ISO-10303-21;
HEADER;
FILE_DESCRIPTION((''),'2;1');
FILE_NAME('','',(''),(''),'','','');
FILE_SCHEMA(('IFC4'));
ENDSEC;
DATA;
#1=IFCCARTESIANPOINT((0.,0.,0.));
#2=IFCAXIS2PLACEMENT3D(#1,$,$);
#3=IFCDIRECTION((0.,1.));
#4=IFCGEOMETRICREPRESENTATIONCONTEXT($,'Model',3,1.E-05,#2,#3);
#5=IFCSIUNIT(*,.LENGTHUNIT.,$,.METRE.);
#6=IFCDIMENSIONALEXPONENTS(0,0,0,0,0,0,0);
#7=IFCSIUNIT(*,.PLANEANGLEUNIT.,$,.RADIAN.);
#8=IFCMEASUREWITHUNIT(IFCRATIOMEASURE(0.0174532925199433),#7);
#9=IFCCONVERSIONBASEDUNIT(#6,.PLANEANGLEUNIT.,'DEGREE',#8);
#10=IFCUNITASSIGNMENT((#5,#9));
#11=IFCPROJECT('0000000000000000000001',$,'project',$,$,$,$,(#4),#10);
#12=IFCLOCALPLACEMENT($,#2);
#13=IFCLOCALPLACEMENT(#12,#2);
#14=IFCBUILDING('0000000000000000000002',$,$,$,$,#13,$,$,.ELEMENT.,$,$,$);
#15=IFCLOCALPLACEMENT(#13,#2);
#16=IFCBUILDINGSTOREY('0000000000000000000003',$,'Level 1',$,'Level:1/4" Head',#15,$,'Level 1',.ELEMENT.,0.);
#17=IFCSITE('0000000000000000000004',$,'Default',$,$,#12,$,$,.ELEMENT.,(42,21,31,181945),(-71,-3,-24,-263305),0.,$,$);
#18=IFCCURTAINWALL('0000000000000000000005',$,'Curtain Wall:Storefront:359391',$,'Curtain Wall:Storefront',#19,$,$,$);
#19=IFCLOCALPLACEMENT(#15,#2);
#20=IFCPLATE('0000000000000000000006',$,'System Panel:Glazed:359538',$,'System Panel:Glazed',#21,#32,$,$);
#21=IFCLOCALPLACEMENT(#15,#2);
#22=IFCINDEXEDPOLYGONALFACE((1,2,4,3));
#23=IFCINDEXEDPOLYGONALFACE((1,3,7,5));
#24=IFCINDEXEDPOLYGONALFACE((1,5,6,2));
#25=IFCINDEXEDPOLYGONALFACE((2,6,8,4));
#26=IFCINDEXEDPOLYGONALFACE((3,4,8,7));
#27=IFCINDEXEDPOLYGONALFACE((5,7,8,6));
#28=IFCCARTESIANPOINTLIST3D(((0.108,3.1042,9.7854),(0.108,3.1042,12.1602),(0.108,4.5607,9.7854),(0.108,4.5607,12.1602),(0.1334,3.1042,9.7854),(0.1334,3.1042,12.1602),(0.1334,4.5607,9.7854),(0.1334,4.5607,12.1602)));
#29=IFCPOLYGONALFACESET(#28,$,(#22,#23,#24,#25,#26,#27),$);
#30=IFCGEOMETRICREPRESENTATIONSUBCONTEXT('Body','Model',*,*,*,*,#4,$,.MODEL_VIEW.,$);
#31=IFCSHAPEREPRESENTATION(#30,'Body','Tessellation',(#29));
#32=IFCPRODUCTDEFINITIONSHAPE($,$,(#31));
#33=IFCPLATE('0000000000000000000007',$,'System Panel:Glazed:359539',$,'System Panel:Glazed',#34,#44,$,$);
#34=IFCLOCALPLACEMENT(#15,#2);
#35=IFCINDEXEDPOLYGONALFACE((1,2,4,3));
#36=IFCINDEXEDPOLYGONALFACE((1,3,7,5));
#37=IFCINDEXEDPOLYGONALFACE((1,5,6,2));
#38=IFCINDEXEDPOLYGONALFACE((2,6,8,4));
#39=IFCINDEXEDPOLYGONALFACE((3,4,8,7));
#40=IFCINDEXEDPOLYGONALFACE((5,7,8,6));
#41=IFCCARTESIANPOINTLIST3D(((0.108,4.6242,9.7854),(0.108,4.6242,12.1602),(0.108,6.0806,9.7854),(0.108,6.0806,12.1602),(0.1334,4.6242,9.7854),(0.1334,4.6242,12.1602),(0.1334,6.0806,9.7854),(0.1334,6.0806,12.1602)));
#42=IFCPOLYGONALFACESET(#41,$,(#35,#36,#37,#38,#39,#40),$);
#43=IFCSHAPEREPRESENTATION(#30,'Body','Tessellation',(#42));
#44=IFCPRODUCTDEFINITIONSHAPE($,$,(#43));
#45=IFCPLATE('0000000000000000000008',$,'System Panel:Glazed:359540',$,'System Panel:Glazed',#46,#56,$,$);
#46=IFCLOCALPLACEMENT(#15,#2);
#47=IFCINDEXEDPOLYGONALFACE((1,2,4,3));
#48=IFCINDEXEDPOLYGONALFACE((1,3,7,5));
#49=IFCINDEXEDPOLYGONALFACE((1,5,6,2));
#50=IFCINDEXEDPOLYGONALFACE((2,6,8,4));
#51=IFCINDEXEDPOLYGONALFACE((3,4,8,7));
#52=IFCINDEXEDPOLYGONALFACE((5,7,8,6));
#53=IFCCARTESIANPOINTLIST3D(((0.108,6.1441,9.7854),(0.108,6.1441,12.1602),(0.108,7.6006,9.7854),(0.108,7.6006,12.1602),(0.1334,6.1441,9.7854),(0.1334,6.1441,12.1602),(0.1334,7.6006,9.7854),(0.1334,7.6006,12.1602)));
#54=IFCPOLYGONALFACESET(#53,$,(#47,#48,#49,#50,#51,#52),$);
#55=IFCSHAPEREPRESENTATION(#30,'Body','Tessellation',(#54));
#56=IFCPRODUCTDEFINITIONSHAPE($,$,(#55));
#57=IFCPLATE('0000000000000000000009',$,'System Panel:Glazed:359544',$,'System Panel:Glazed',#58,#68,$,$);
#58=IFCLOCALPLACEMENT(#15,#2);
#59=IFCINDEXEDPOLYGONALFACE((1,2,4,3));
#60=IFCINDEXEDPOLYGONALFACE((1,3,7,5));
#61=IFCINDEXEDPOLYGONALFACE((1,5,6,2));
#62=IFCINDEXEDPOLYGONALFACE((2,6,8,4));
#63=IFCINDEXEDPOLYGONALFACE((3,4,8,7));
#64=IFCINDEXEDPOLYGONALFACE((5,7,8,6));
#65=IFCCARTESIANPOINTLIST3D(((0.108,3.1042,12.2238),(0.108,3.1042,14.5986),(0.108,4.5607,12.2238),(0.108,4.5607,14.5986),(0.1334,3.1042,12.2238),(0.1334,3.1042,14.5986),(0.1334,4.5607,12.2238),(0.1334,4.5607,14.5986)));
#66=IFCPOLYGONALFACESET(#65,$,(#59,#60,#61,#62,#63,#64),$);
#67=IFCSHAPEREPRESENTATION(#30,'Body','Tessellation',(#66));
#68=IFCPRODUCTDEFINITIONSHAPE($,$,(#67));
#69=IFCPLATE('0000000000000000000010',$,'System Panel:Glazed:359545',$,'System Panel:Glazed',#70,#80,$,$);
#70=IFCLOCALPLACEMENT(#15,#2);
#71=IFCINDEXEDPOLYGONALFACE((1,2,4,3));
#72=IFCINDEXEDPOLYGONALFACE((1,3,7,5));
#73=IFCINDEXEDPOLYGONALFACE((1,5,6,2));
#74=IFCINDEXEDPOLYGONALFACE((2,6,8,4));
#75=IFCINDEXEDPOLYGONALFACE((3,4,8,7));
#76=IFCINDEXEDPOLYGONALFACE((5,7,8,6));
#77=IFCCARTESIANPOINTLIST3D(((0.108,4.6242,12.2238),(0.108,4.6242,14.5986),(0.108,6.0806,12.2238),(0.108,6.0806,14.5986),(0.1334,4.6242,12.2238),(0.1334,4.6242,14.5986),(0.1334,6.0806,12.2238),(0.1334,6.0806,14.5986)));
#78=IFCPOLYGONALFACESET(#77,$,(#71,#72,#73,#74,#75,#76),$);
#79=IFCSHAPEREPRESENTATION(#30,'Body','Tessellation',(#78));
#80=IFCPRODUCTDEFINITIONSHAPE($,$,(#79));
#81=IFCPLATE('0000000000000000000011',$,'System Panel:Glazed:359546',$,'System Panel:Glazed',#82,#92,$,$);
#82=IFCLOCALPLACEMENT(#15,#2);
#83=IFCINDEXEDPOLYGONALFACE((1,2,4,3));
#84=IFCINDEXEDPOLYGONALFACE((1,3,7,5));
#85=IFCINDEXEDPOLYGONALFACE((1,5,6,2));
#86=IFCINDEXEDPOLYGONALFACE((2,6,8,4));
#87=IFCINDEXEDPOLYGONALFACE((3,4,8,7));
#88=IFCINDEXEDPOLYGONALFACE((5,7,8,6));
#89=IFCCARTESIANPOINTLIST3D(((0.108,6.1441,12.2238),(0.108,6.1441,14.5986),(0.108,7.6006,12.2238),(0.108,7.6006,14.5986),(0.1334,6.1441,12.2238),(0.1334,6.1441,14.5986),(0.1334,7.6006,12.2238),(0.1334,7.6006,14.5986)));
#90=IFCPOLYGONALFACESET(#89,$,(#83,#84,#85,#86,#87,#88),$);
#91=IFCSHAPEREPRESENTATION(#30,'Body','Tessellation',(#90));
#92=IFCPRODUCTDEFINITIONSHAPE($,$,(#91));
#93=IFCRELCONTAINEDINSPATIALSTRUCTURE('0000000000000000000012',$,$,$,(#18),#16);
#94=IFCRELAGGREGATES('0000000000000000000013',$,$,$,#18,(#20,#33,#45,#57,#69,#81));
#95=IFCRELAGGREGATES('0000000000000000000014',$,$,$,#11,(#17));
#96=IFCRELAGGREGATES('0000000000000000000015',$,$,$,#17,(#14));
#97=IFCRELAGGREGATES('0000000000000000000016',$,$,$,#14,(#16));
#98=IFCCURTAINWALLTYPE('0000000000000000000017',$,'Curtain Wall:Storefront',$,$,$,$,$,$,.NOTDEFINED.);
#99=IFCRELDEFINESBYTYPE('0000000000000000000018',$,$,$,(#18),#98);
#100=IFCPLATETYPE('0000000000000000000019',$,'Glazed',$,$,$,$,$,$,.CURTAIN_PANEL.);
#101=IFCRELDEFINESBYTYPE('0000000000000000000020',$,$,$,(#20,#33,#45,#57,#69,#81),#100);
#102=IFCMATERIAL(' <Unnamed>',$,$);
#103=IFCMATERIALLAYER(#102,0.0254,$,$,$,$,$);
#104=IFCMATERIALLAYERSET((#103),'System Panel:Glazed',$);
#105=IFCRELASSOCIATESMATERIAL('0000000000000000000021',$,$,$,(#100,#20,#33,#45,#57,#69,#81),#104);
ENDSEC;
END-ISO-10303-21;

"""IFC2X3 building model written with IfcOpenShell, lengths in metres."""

from ifc_helpers import new_model, entity, si_unit, converted_unit, direction, frame, frame_2d, origin, place, context, subcontext, project, spatial, rectangle, extrude, source, transform, mapped, material, layer, layer_set, layer_usage, type_object, type_shapes, element, aggregate, save


model = new_model("IFC2X3")

# Units and contexts
model_context = context("Model", 3, precision=1e-05, world=origin(), true_north=direction((0.0, 1.0)))
body_context = subcontext(model_context, "Body", "Model", "MODEL_VIEW")
ifc_project = project(units=[si_unit("LENGTHUNIT", "METRE"), converted_unit("PLANEANGLEUNIT", "DEGREE", entity("IfcRatioMeasure", 0.0174532925199433), si_unit("PLANEANGLEUNIT", "RADIAN"), dimensions=[0, 0, 0, 0, 0, 0, 0])], contexts=[model_context])

# Site, building, storey
site_placement = place(None, origin())
site = spatial("IfcSite", under=ifc_project, at=site_placement, Name="Default", CompositionType="ELEMENT", RefLatitude=(42, 21, 31, 181945), RefLongitude=(-71, -3, -24, -263305), RefElevation=0.0)
building_placement = place(site_placement, origin())
building = spatial("IfcBuilding", under=site, at=building_placement, CompositionType="ELEMENT")
storey_placement = place(building_placement, origin())
storey = spatial("IfcBuildingStorey", under=building, at=storey_placement, Name="Level 1", ObjectType="Level:1/4\" Head", LongName="Level 1", CompositionType="ELEMENT", Elevation=0.0)

# Curtain wall, plates
curtain_wall_type = type_object("IfcCurtainWallType", Name="Curtain Wall:Storefront", PredefinedType="NOTDEFINED")
curtain_wall_placement = place(storey_placement, origin())
curtain_wall = element("IfcCurtainWall", 1, at=curtain_wall_placement, inside=storey, type_object=curtain_wall_type, Name="Curtain Wall:Storefront:359391", ObjectType="Curtain Wall:Storefront")
ifc_material_1 = material(Name=" <Unnamed>")
ifc_layer = layer(ifc_material_1, 0.0254)
ifc_layer_set = layer_set([ifc_layer], Name="System Panel:Glazed")
ifc_layer_usage_1 = layer_usage(ifc_layer_set, "AXIS3", "POSITIVE", 0.1042)
plate_type_1 = type_object("IfcPlateType", Name="Glazed", PredefinedType="CURTAIN_PANEL", material=ifc_layer_set)
shared_shape_1 = source(origin(), body_context, "Body", "SweptSolid", [
    extrude(rectangle(XDim=0.0254, YDim=1.4565, at=frame_2d((0.0, 0.0), x_axis=(1.0, 0.0))), frame((0.7282, 0.0127, 0.0), z_axis=(0.0, 0.0, 1.0), x_axis=(0.0, 1.0, 0.0)), (0.0, 0.0, 1.0), 2.3749),
])
type_shapes(plate_type_1, [shared_shape_1])
plate_1_placement = place(curtain_wall_placement, frame((0.1334, 3.1042, 9.7853), z_axis=(0.0, 0.0, 1.0), x_axis=(0.0, 1.0, 0.0)))
plate_1 = element("IfcPlate", 2, at=plate_1_placement, type_object=plate_type_1, material=ifc_layer_usage_1, Name="System Panel:Glazed:359538", ObjectType="System Panel:Glazed", context=body_context, shape_type="MappedRepresentation", body=[
    mapped(shared_shape_1, transform((0.0, 0.0, 0.0), scale=1.0)),
])
ifc_layer_usage_2 = layer_usage(ifc_layer_set, "AXIS3", "POSITIVE", 0.1042)
plate_2_placement = place(curtain_wall_placement, frame((0.1334, 4.6242, 9.7853), z_axis=(0.0, 0.0, 1.0), x_axis=(0.0, 1.0, 0.0)))
plate_2 = element("IfcPlate", 3, at=plate_2_placement, type_object=plate_type_1, material=ifc_layer_usage_2, Name="System Panel:Glazed:359539", ObjectType="System Panel:Glazed", context=body_context, shape_type="MappedRepresentation", body=[
    mapped(shared_shape_1, transform((0.0, 0.0, 0.0), scale=1.0)),
])
ifc_layer_usage_3 = layer_usage(ifc_layer_set, "AXIS3", "POSITIVE", 0.1042)
plate_3_placement = place(curtain_wall_placement, frame((0.1334, 6.1441, 9.7853), z_axis=(0.0, 0.0, 1.0), x_axis=(0.0, 1.0, 0.0)))
plate_3 = element("IfcPlate", 4, at=plate_3_placement, type_object=plate_type_1, material=ifc_layer_usage_3, Name="System Panel:Glazed:359540", ObjectType="System Panel:Glazed", context=body_context, shape_type="MappedRepresentation", body=[
    mapped(shared_shape_1, transform((0.0, 0.0, 0.0), scale=1.0)),
])
ifc_layer_usage_4 = layer_usage(ifc_layer_set, "AXIS3", "POSITIVE", 0.1042)
plate_4_placement = place(curtain_wall_placement, frame((0.1334, 3.1042, 12.2238), z_axis=(0.0, 0.0, 1.0), x_axis=(0.0, 1.0, 0.0)))
plate_4 = element("IfcPlate", 5, at=plate_4_placement, type_object=plate_type_1, material=ifc_layer_usage_4, Name="System Panel:Glazed:359544", ObjectType="System Panel:Glazed", context=body_context, shape_type="MappedRepresentation", body=[
    mapped(shared_shape_1, transform((0.0, 0.0, 0.0), scale=1.0)),
])
ifc_layer_usage_5 = layer_usage(ifc_layer_set, "AXIS3", "POSITIVE", 0.1042)
plate_5_placement = place(curtain_wall_placement, frame((0.1334, 4.6242, 12.2238), z_axis=(0.0, 0.0, 1.0), x_axis=(0.0, 1.0, 0.0)))
plate_5 = element("IfcPlate", 6, at=plate_5_placement, type_object=plate_type_1, material=ifc_layer_usage_5, Name="System Panel:Glazed:359545", ObjectType="System Panel:Glazed", context=body_context, shape_type="MappedRepresentation", body=[
    mapped(shared_shape_1, transform((0.0, 0.0, 0.0), scale=1.0)),
])
ifc_layer_usage_6 = layer_usage(ifc_layer_set, "AXIS3", "POSITIVE", 0.1042)
plate_6_placement = place(curtain_wall_placement, frame((0.1334, 6.1441, 12.2238), z_axis=(0.0, 0.0, 1.0), x_axis=(0.0, 1.0, 0.0)))
plate_6 = element("IfcPlate", 7, at=plate_6_placement, type_object=plate_type_1, material=ifc_layer_usage_6, Name="System Panel:Glazed:359546", ObjectType="System Panel:Glazed", context=body_context, shape_type="MappedRepresentation", body=[
    mapped(shared_shape_1, transform((0.0, 0.0, 0.0), scale=1.0)),
])
aggregate(curtain_wall, [plate_1, plate_2, plate_3, plate_4, plate_5, plate_6])

save(model, "model.ifc")
